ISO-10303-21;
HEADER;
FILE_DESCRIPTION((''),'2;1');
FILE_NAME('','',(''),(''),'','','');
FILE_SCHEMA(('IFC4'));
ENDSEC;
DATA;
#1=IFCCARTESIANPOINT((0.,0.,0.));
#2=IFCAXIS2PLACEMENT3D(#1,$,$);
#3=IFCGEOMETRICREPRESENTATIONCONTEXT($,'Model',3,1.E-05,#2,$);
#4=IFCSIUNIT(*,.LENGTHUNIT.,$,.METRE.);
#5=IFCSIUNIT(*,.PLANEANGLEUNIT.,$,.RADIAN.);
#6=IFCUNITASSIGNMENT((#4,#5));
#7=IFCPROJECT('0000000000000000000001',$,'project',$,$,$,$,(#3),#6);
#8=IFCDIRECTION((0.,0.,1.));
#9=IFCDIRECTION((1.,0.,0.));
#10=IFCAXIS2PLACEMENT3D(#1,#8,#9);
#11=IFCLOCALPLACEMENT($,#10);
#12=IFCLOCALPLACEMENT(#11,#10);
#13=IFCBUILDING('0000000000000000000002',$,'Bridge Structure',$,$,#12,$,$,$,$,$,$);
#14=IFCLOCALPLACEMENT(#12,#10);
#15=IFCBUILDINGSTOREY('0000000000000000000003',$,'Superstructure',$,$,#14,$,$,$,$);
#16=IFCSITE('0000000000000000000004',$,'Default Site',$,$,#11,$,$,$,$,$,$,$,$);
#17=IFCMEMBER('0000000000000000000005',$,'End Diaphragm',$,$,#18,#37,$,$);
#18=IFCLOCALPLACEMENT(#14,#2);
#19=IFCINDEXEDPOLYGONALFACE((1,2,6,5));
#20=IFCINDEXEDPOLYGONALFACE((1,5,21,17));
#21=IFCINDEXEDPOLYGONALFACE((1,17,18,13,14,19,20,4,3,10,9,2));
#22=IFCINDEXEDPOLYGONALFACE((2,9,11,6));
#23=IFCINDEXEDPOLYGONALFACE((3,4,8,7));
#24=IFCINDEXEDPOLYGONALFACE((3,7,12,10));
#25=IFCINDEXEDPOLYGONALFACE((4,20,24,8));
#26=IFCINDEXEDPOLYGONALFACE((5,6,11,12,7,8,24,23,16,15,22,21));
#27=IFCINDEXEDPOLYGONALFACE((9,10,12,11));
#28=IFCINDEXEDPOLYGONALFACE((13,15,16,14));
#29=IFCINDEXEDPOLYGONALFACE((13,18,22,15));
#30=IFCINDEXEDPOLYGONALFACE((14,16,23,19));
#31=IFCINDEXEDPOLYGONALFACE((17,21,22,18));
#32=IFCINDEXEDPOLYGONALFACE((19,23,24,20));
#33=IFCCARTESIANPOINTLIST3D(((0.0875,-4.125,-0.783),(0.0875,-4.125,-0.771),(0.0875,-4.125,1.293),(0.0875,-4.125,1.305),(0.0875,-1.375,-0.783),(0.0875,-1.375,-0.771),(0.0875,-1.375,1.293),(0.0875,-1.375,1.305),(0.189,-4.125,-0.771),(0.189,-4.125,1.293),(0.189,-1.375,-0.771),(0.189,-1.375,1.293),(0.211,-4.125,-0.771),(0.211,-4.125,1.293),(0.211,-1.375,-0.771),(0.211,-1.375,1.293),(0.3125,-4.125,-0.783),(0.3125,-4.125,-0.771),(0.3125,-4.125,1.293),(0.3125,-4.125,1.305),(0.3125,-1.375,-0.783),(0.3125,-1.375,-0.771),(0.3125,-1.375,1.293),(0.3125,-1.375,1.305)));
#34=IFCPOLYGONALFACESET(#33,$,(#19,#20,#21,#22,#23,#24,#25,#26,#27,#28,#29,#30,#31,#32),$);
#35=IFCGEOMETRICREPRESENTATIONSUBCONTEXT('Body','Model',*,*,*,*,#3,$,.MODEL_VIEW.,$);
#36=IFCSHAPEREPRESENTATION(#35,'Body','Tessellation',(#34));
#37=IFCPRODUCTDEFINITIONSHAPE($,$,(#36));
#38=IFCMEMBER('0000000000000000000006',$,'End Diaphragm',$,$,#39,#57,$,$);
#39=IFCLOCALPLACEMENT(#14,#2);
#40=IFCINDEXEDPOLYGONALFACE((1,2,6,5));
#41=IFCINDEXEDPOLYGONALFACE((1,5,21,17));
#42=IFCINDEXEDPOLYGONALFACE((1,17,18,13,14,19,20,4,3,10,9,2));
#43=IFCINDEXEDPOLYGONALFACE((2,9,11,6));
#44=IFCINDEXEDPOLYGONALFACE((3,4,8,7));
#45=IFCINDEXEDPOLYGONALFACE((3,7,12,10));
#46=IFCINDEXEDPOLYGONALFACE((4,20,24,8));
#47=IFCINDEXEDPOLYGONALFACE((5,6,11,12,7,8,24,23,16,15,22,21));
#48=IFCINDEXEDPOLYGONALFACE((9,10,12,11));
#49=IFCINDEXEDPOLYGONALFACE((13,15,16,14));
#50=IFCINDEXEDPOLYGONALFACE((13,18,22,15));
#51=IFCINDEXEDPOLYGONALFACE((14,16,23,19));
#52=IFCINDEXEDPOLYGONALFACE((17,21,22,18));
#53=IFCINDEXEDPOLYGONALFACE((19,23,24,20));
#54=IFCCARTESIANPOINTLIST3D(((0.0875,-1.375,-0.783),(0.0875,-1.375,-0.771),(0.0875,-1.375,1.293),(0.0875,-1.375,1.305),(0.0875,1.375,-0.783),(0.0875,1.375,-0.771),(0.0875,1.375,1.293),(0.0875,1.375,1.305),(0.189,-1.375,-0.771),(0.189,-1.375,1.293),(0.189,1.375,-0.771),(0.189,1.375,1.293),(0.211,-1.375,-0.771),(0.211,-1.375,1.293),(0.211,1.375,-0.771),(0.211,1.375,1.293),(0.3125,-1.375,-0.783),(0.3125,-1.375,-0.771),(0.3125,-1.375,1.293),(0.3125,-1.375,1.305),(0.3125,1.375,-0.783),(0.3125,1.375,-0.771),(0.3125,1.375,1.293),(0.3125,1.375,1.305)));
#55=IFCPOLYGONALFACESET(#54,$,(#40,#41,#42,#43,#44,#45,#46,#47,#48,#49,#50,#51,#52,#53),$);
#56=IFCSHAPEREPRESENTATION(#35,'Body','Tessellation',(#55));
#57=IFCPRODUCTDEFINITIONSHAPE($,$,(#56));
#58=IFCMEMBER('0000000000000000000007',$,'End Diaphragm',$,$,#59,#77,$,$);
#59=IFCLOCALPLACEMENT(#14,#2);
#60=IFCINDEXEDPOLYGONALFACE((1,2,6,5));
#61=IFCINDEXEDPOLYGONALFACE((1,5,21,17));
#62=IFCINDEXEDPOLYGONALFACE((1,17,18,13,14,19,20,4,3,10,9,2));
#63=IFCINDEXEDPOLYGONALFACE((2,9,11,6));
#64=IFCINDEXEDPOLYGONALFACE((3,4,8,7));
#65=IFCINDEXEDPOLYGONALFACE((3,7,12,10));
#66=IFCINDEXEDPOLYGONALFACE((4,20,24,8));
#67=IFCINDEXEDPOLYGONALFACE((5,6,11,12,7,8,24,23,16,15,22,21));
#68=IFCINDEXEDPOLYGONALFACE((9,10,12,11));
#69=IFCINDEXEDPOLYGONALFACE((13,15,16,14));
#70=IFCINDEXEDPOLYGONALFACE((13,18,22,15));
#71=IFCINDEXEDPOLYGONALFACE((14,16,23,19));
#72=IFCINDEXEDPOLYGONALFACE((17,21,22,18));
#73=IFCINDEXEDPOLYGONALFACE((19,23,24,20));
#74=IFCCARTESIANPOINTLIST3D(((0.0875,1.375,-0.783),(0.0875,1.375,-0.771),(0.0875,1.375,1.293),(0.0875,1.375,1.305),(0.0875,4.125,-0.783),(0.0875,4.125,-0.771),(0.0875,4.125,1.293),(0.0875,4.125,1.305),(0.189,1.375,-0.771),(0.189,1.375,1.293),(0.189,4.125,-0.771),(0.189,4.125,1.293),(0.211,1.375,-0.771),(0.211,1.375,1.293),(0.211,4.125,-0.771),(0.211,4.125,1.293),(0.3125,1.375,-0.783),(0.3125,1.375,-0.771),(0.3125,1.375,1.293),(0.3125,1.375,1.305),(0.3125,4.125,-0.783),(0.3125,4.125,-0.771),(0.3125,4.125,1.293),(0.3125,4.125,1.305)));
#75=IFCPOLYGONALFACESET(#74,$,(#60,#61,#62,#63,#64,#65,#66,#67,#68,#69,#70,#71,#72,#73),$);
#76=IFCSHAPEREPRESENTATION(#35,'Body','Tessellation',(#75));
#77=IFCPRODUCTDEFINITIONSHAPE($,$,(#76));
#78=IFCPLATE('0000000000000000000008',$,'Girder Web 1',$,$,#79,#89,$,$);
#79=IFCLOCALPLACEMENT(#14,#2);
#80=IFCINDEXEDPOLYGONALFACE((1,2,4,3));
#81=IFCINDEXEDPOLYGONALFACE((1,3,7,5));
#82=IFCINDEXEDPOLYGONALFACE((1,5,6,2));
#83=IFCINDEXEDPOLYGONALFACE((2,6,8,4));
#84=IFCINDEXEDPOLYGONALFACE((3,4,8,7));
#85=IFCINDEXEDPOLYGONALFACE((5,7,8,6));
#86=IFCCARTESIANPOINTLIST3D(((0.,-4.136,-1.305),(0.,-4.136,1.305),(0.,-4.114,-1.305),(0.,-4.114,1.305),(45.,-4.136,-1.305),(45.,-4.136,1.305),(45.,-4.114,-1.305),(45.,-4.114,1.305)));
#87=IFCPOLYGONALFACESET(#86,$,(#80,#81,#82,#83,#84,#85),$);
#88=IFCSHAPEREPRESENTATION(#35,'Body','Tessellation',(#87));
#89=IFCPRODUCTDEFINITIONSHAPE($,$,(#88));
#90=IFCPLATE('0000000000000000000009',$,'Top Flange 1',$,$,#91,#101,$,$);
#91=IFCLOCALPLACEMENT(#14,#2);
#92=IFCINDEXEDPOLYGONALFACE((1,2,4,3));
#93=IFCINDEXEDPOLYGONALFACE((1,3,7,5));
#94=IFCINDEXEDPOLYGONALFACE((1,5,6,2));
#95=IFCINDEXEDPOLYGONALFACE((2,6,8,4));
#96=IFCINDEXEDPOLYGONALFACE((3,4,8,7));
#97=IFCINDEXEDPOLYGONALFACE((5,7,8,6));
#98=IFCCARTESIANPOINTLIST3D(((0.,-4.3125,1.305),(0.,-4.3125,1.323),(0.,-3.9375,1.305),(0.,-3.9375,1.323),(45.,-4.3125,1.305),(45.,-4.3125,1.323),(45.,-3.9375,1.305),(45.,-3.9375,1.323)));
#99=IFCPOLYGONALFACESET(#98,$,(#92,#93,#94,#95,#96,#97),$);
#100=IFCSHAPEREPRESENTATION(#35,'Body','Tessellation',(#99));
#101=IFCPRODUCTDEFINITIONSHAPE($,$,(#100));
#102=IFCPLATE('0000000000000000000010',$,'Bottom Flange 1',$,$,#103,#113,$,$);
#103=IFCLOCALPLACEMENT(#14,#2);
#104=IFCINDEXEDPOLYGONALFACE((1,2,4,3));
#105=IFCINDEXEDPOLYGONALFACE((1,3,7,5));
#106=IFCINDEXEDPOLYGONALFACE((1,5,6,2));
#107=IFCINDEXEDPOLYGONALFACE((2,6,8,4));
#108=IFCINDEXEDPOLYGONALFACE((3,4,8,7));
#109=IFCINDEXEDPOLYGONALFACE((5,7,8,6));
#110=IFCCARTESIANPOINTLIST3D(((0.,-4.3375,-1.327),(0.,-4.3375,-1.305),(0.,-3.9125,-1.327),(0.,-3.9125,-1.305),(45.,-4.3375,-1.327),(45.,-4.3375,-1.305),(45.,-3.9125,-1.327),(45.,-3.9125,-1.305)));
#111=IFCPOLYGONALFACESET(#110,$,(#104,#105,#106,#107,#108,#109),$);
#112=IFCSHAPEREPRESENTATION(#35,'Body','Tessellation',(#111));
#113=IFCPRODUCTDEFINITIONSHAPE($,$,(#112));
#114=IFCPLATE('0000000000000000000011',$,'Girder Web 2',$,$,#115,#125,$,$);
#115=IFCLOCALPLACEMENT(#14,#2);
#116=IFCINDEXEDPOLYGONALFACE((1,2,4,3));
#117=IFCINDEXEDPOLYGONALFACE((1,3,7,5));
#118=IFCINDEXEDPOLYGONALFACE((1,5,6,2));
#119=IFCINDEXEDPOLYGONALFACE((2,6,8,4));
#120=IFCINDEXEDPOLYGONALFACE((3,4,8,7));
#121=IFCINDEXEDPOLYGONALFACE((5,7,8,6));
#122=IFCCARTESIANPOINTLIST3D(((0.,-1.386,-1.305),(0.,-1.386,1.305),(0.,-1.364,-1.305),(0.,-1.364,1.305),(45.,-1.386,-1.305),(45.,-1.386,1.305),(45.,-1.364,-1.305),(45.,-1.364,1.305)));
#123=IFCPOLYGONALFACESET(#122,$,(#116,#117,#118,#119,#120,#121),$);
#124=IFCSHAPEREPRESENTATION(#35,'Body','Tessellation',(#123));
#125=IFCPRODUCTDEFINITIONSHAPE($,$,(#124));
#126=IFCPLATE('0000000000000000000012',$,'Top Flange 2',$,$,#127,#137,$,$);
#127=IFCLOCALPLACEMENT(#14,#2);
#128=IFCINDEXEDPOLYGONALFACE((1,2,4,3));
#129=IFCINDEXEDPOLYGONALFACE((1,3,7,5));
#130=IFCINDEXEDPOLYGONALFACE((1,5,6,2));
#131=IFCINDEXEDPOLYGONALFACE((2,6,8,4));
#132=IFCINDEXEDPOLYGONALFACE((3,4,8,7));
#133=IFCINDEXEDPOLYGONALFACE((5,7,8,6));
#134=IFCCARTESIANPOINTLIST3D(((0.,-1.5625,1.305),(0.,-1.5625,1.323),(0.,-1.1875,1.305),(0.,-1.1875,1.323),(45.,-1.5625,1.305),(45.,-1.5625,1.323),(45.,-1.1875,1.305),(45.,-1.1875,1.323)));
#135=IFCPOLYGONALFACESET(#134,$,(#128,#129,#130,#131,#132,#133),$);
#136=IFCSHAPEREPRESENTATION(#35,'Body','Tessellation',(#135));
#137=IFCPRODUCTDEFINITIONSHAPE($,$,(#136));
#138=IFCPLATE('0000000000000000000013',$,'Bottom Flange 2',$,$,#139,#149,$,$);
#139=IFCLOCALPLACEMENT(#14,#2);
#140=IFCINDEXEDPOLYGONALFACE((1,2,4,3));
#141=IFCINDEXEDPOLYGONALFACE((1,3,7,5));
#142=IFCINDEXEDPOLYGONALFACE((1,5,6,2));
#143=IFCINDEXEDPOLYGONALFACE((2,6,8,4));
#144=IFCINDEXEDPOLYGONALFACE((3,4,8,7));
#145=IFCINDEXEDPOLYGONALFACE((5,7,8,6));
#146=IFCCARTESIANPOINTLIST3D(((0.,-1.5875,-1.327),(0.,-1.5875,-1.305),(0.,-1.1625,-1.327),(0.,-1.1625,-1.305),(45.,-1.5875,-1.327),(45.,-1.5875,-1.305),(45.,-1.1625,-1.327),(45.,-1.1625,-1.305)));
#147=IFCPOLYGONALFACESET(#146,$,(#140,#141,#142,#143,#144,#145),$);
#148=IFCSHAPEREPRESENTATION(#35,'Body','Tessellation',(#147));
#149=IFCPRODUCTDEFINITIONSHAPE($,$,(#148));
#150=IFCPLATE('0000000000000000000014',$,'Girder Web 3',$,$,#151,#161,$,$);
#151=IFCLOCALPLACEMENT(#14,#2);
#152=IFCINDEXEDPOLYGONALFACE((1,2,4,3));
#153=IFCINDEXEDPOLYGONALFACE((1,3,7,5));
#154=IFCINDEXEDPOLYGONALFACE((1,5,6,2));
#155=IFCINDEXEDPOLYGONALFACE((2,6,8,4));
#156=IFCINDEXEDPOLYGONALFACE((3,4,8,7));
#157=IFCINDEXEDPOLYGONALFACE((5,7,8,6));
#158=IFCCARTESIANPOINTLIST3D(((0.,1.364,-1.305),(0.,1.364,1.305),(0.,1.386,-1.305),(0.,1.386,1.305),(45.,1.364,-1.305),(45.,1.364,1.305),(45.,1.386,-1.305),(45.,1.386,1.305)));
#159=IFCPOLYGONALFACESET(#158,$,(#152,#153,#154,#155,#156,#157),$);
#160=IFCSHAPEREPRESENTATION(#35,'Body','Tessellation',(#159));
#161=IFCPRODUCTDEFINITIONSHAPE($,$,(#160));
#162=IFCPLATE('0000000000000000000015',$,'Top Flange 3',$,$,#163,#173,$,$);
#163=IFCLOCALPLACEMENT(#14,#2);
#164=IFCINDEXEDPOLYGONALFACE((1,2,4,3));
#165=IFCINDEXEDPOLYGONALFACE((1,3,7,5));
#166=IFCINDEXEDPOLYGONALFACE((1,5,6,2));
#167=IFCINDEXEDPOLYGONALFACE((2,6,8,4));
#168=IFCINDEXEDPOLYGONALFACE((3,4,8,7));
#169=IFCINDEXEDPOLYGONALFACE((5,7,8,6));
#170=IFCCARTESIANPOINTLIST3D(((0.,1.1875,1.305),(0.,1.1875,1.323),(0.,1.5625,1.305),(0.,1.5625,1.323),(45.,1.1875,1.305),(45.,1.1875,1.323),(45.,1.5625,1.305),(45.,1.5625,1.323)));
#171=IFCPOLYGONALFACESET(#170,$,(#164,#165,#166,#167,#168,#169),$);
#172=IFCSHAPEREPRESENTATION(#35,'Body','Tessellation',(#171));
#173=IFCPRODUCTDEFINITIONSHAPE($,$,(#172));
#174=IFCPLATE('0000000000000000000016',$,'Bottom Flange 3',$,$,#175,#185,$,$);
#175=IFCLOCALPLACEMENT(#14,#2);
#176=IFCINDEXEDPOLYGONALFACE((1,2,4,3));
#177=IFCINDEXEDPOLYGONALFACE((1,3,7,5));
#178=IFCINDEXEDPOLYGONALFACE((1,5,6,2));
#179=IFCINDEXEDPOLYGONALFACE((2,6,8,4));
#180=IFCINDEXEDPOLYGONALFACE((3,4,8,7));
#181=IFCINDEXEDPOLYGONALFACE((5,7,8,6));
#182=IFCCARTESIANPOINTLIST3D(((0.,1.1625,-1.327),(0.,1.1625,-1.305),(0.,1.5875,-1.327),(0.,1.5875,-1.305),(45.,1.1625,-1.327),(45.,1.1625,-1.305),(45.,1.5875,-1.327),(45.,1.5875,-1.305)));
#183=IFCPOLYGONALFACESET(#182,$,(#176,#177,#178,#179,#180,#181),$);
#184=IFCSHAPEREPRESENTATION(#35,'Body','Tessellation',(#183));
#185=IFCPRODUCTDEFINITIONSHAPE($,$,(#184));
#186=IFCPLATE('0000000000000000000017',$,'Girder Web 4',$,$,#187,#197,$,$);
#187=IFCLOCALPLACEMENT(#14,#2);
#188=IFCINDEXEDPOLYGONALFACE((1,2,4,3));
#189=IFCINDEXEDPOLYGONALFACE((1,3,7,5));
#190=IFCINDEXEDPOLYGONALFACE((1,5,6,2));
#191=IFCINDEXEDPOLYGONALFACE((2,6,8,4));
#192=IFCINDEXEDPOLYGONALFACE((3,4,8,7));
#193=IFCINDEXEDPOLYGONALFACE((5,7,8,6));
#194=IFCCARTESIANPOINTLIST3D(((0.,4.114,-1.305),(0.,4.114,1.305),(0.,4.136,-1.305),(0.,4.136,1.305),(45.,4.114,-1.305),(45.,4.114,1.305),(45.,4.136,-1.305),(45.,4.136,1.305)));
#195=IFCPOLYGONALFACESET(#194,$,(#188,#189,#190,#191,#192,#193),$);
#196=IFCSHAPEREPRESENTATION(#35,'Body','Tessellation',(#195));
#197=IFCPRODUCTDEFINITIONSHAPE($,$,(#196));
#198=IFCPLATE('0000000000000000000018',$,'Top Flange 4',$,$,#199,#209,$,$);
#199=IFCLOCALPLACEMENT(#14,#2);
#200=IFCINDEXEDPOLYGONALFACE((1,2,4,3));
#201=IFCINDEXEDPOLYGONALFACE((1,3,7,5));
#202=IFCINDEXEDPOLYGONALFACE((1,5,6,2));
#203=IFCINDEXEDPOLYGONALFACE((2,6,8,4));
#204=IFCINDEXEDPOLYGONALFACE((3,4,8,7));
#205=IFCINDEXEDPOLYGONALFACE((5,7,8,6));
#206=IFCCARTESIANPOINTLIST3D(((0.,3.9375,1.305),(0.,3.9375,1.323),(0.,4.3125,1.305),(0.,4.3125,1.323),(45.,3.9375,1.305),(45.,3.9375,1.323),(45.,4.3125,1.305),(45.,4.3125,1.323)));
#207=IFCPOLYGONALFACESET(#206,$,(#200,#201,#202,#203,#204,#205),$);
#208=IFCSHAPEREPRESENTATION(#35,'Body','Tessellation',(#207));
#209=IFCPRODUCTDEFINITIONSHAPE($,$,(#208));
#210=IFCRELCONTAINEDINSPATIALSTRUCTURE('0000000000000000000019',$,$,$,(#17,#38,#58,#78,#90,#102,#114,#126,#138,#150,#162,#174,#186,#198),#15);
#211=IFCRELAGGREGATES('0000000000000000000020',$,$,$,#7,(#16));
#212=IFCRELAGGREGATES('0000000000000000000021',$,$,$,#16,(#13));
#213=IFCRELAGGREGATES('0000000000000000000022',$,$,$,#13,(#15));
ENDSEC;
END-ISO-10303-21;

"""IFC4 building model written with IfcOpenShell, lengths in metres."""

from ifc_helpers import new_model, si_unit, frame, origin, origin_with_axes, origin_2d_with_axis, place, context, subcontext, project, spatial, rectangle, i_section, extrude, element, save


model = new_model("IFC4")

# Units and contexts
model_context = context("Model", 3, precision=1e-05, world=origin())
body_context = subcontext(model_context, "Body", "Model", "MODEL_VIEW")
ifc_project = project(units=[si_unit("LENGTHUNIT", "METRE"), si_unit("PLANEANGLEUNIT", "RADIAN")], contexts=[model_context])

# Site, building, storey
site_placement = place(None, origin_with_axes())
site = spatial("IfcSite", under=ifc_project, at=site_placement, Name="Default Site")
building_placement = place(site_placement, origin_with_axes())
building = spatial("IfcBuilding", under=site, at=building_placement, Name="Bridge Structure")
storey_placement = place(building_placement, origin_with_axes())
storey = spatial("IfcBuildingStorey", under=building, at=storey_placement, Name="Superstructure")

# Members
for number, where, z_axis, x_axis, name in (
    (1, (0.2, -4.125, 0.261), (0.0, 1.0, 0.0), (-1.0, 0.0, 0.0), "End Diaphragm"),
    (2, (0.2, -1.375, 0.261), (0.0, 1.0, 0.0), (-1.0, 0.0, 0.0), "End Diaphragm"),
    (3, (0.2, 1.375, 0.261), (0.0, 1.0, 0.0), (-1.0, 0.0, 0.0), "End Diaphragm"),
):
    element("IfcMember", number, at=place(storey_placement, frame(where, z_axis=z_axis, x_axis=x_axis)), inside=storey, Name=name, context=body_context, shape_type="SweptSolid", body=[
        extrude(i_section(OverallWidth=0.225, OverallDepth=2.088, WebThickness=0.022, FlangeThickness=0.012, at=origin_2d_with_axis()), origin_with_axes(), (0.0, 0.0, 1.0), 2.75),
    ])

# Plates
plate_1_placement = place(storey_placement, frame((0.0, -4.125, 0.0), z_axis=(1.0, 0.0, 0.0), x_axis=(0.0, 1.0, 0.0)))
element("IfcPlate", 4, at=plate_1_placement, inside=storey, Name="Girder Web 1", context=body_context, shape_type="SweptSolid", body=[
    extrude(rectangle(XDim=0.022, YDim=2.61, at=origin_2d_with_axis()), origin_with_axes(), (0.0, 0.0, 1.0), 45.0),
])
plate_2_placement = place(storey_placement, frame((0.0, -4.125, 1.314), z_axis=(1.0, 0.0, 0.0), x_axis=(0.0, 1.0, 0.0)))
element("IfcPlate", 5, at=plate_2_placement, inside=storey, Name="Top Flange 1", context=body_context, shape_type="SweptSolid", body=[
    extrude(rectangle(XDim=0.375, YDim=0.018, at=origin_2d_with_axis()), origin_with_axes(), (0.0, 0.0, 1.0), 45.0),
])
plate_3_placement = place(storey_placement, frame((0.0, -4.125, -1.316), z_axis=(1.0, 0.0, 0.0), x_axis=(0.0, 1.0, 0.0)))
element("IfcPlate", 6, at=plate_3_placement, inside=storey, Name="Bottom Flange 1", context=body_context, shape_type="SweptSolid", body=[
    extrude(rectangle(XDim=0.425, YDim=0.022, at=origin_2d_with_axis()), origin_with_axes(), (0.0, 0.0, 1.0), 45.0),
])
plate_4_placement = place(storey_placement, frame((0.0, -1.375, 0.0), z_axis=(1.0, 0.0, 0.0), x_axis=(0.0, 1.0, 0.0)))
element("IfcPlate", 7, at=plate_4_placement, inside=storey, Name="Girder Web 2", context=body_context, shape_type="SweptSolid", body=[
    extrude(rectangle(XDim=0.022, YDim=2.61, at=origin_2d_with_axis()), origin_with_axes(), (0.0, 0.0, 1.0), 45.0),
])
plate_5_placement = place(storey_placement, frame((0.0, -1.375, 1.314), z_axis=(1.0, 0.0, 0.0), x_axis=(0.0, 1.0, 0.0)))
element("IfcPlate", 8, at=plate_5_placement, inside=storey, Name="Top Flange 2", context=body_context, shape_type="SweptSolid", body=[
    extrude(rectangle(XDim=0.375, YDim=0.018, at=origin_2d_with_axis()), origin_with_axes(), (0.0, 0.0, 1.0), 45.0),
])
plate_6_placement = place(storey_placement, frame((0.0, -1.375, -1.316), z_axis=(1.0, 0.0, 0.0), x_axis=(0.0, 1.0, 0.0)))
element("IfcPlate", 9, at=plate_6_placement, inside=storey, Name="Bottom Flange 2", context=body_context, shape_type="SweptSolid", body=[
    extrude(rectangle(XDim=0.425, YDim=0.022, at=origin_2d_with_axis()), origin_with_axes(), (0.0, 0.0, 1.0), 45.0),
])
plate_7_placement = place(storey_placement, frame((0.0, 1.375, 0.0), z_axis=(1.0, 0.0, 0.0), x_axis=(0.0, 1.0, 0.0)))
element("IfcPlate", 10, at=plate_7_placement, inside=storey, Name="Girder Web 3", context=body_context, shape_type="SweptSolid", body=[
    extrude(rectangle(XDim=0.022, YDim=2.61, at=origin_2d_with_axis()), origin_with_axes(), (0.0, 0.0, 1.0), 45.0),
])
plate_8_placement = place(storey_placement, frame((0.0, 1.375, 1.314), z_axis=(1.0, 0.0, 0.0), x_axis=(0.0, 1.0, 0.0)))
element("IfcPlate", 11, at=plate_8_placement, inside=storey, Name="Top Flange 3", context=body_context, shape_type="SweptSolid", body=[
    extrude(rectangle(XDim=0.375, YDim=0.018, at=origin_2d_with_axis()), origin_with_axes(), (0.0, 0.0, 1.0), 45.0),
])
plate_9_placement = place(storey_placement, frame((0.0, 1.375, -1.316), z_axis=(1.0, 0.0, 0.0), x_axis=(0.0, 1.0, 0.0)))
element("IfcPlate", 12, at=plate_9_placement, inside=storey, Name="Bottom Flange 3", context=body_context, shape_type="SweptSolid", body=[
    extrude(rectangle(XDim=0.425, YDim=0.022, at=origin_2d_with_axis()), origin_with_axes(), (0.0, 0.0, 1.0), 45.0),
])
plate_10_placement = place(storey_placement, frame((0.0, 4.125, 0.0), z_axis=(1.0, 0.0, 0.0), x_axis=(0.0, 1.0, 0.0)))
element("IfcPlate", 13, at=plate_10_placement, inside=storey, Name="Girder Web 4", context=body_context, shape_type="SweptSolid", body=[
    extrude(rectangle(XDim=0.022, YDim=2.61, at=origin_2d_with_axis()), origin_with_axes(), (0.0, 0.0, 1.0), 45.0),
])
plate_11_placement = place(storey_placement, frame((0.0, 4.125, 1.314), z_axis=(1.0, 0.0, 0.0), x_axis=(0.0, 1.0, 0.0)))
element("IfcPlate", 14, at=plate_11_placement, inside=storey, Name="Top Flange 4", context=body_context, shape_type="SweptSolid", body=[
    extrude(rectangle(XDim=0.375, YDim=0.018, at=origin_2d_with_axis()), origin_with_axes(), (0.0, 0.0, 1.0), 45.0),
])

save(model, "model.ifc")
